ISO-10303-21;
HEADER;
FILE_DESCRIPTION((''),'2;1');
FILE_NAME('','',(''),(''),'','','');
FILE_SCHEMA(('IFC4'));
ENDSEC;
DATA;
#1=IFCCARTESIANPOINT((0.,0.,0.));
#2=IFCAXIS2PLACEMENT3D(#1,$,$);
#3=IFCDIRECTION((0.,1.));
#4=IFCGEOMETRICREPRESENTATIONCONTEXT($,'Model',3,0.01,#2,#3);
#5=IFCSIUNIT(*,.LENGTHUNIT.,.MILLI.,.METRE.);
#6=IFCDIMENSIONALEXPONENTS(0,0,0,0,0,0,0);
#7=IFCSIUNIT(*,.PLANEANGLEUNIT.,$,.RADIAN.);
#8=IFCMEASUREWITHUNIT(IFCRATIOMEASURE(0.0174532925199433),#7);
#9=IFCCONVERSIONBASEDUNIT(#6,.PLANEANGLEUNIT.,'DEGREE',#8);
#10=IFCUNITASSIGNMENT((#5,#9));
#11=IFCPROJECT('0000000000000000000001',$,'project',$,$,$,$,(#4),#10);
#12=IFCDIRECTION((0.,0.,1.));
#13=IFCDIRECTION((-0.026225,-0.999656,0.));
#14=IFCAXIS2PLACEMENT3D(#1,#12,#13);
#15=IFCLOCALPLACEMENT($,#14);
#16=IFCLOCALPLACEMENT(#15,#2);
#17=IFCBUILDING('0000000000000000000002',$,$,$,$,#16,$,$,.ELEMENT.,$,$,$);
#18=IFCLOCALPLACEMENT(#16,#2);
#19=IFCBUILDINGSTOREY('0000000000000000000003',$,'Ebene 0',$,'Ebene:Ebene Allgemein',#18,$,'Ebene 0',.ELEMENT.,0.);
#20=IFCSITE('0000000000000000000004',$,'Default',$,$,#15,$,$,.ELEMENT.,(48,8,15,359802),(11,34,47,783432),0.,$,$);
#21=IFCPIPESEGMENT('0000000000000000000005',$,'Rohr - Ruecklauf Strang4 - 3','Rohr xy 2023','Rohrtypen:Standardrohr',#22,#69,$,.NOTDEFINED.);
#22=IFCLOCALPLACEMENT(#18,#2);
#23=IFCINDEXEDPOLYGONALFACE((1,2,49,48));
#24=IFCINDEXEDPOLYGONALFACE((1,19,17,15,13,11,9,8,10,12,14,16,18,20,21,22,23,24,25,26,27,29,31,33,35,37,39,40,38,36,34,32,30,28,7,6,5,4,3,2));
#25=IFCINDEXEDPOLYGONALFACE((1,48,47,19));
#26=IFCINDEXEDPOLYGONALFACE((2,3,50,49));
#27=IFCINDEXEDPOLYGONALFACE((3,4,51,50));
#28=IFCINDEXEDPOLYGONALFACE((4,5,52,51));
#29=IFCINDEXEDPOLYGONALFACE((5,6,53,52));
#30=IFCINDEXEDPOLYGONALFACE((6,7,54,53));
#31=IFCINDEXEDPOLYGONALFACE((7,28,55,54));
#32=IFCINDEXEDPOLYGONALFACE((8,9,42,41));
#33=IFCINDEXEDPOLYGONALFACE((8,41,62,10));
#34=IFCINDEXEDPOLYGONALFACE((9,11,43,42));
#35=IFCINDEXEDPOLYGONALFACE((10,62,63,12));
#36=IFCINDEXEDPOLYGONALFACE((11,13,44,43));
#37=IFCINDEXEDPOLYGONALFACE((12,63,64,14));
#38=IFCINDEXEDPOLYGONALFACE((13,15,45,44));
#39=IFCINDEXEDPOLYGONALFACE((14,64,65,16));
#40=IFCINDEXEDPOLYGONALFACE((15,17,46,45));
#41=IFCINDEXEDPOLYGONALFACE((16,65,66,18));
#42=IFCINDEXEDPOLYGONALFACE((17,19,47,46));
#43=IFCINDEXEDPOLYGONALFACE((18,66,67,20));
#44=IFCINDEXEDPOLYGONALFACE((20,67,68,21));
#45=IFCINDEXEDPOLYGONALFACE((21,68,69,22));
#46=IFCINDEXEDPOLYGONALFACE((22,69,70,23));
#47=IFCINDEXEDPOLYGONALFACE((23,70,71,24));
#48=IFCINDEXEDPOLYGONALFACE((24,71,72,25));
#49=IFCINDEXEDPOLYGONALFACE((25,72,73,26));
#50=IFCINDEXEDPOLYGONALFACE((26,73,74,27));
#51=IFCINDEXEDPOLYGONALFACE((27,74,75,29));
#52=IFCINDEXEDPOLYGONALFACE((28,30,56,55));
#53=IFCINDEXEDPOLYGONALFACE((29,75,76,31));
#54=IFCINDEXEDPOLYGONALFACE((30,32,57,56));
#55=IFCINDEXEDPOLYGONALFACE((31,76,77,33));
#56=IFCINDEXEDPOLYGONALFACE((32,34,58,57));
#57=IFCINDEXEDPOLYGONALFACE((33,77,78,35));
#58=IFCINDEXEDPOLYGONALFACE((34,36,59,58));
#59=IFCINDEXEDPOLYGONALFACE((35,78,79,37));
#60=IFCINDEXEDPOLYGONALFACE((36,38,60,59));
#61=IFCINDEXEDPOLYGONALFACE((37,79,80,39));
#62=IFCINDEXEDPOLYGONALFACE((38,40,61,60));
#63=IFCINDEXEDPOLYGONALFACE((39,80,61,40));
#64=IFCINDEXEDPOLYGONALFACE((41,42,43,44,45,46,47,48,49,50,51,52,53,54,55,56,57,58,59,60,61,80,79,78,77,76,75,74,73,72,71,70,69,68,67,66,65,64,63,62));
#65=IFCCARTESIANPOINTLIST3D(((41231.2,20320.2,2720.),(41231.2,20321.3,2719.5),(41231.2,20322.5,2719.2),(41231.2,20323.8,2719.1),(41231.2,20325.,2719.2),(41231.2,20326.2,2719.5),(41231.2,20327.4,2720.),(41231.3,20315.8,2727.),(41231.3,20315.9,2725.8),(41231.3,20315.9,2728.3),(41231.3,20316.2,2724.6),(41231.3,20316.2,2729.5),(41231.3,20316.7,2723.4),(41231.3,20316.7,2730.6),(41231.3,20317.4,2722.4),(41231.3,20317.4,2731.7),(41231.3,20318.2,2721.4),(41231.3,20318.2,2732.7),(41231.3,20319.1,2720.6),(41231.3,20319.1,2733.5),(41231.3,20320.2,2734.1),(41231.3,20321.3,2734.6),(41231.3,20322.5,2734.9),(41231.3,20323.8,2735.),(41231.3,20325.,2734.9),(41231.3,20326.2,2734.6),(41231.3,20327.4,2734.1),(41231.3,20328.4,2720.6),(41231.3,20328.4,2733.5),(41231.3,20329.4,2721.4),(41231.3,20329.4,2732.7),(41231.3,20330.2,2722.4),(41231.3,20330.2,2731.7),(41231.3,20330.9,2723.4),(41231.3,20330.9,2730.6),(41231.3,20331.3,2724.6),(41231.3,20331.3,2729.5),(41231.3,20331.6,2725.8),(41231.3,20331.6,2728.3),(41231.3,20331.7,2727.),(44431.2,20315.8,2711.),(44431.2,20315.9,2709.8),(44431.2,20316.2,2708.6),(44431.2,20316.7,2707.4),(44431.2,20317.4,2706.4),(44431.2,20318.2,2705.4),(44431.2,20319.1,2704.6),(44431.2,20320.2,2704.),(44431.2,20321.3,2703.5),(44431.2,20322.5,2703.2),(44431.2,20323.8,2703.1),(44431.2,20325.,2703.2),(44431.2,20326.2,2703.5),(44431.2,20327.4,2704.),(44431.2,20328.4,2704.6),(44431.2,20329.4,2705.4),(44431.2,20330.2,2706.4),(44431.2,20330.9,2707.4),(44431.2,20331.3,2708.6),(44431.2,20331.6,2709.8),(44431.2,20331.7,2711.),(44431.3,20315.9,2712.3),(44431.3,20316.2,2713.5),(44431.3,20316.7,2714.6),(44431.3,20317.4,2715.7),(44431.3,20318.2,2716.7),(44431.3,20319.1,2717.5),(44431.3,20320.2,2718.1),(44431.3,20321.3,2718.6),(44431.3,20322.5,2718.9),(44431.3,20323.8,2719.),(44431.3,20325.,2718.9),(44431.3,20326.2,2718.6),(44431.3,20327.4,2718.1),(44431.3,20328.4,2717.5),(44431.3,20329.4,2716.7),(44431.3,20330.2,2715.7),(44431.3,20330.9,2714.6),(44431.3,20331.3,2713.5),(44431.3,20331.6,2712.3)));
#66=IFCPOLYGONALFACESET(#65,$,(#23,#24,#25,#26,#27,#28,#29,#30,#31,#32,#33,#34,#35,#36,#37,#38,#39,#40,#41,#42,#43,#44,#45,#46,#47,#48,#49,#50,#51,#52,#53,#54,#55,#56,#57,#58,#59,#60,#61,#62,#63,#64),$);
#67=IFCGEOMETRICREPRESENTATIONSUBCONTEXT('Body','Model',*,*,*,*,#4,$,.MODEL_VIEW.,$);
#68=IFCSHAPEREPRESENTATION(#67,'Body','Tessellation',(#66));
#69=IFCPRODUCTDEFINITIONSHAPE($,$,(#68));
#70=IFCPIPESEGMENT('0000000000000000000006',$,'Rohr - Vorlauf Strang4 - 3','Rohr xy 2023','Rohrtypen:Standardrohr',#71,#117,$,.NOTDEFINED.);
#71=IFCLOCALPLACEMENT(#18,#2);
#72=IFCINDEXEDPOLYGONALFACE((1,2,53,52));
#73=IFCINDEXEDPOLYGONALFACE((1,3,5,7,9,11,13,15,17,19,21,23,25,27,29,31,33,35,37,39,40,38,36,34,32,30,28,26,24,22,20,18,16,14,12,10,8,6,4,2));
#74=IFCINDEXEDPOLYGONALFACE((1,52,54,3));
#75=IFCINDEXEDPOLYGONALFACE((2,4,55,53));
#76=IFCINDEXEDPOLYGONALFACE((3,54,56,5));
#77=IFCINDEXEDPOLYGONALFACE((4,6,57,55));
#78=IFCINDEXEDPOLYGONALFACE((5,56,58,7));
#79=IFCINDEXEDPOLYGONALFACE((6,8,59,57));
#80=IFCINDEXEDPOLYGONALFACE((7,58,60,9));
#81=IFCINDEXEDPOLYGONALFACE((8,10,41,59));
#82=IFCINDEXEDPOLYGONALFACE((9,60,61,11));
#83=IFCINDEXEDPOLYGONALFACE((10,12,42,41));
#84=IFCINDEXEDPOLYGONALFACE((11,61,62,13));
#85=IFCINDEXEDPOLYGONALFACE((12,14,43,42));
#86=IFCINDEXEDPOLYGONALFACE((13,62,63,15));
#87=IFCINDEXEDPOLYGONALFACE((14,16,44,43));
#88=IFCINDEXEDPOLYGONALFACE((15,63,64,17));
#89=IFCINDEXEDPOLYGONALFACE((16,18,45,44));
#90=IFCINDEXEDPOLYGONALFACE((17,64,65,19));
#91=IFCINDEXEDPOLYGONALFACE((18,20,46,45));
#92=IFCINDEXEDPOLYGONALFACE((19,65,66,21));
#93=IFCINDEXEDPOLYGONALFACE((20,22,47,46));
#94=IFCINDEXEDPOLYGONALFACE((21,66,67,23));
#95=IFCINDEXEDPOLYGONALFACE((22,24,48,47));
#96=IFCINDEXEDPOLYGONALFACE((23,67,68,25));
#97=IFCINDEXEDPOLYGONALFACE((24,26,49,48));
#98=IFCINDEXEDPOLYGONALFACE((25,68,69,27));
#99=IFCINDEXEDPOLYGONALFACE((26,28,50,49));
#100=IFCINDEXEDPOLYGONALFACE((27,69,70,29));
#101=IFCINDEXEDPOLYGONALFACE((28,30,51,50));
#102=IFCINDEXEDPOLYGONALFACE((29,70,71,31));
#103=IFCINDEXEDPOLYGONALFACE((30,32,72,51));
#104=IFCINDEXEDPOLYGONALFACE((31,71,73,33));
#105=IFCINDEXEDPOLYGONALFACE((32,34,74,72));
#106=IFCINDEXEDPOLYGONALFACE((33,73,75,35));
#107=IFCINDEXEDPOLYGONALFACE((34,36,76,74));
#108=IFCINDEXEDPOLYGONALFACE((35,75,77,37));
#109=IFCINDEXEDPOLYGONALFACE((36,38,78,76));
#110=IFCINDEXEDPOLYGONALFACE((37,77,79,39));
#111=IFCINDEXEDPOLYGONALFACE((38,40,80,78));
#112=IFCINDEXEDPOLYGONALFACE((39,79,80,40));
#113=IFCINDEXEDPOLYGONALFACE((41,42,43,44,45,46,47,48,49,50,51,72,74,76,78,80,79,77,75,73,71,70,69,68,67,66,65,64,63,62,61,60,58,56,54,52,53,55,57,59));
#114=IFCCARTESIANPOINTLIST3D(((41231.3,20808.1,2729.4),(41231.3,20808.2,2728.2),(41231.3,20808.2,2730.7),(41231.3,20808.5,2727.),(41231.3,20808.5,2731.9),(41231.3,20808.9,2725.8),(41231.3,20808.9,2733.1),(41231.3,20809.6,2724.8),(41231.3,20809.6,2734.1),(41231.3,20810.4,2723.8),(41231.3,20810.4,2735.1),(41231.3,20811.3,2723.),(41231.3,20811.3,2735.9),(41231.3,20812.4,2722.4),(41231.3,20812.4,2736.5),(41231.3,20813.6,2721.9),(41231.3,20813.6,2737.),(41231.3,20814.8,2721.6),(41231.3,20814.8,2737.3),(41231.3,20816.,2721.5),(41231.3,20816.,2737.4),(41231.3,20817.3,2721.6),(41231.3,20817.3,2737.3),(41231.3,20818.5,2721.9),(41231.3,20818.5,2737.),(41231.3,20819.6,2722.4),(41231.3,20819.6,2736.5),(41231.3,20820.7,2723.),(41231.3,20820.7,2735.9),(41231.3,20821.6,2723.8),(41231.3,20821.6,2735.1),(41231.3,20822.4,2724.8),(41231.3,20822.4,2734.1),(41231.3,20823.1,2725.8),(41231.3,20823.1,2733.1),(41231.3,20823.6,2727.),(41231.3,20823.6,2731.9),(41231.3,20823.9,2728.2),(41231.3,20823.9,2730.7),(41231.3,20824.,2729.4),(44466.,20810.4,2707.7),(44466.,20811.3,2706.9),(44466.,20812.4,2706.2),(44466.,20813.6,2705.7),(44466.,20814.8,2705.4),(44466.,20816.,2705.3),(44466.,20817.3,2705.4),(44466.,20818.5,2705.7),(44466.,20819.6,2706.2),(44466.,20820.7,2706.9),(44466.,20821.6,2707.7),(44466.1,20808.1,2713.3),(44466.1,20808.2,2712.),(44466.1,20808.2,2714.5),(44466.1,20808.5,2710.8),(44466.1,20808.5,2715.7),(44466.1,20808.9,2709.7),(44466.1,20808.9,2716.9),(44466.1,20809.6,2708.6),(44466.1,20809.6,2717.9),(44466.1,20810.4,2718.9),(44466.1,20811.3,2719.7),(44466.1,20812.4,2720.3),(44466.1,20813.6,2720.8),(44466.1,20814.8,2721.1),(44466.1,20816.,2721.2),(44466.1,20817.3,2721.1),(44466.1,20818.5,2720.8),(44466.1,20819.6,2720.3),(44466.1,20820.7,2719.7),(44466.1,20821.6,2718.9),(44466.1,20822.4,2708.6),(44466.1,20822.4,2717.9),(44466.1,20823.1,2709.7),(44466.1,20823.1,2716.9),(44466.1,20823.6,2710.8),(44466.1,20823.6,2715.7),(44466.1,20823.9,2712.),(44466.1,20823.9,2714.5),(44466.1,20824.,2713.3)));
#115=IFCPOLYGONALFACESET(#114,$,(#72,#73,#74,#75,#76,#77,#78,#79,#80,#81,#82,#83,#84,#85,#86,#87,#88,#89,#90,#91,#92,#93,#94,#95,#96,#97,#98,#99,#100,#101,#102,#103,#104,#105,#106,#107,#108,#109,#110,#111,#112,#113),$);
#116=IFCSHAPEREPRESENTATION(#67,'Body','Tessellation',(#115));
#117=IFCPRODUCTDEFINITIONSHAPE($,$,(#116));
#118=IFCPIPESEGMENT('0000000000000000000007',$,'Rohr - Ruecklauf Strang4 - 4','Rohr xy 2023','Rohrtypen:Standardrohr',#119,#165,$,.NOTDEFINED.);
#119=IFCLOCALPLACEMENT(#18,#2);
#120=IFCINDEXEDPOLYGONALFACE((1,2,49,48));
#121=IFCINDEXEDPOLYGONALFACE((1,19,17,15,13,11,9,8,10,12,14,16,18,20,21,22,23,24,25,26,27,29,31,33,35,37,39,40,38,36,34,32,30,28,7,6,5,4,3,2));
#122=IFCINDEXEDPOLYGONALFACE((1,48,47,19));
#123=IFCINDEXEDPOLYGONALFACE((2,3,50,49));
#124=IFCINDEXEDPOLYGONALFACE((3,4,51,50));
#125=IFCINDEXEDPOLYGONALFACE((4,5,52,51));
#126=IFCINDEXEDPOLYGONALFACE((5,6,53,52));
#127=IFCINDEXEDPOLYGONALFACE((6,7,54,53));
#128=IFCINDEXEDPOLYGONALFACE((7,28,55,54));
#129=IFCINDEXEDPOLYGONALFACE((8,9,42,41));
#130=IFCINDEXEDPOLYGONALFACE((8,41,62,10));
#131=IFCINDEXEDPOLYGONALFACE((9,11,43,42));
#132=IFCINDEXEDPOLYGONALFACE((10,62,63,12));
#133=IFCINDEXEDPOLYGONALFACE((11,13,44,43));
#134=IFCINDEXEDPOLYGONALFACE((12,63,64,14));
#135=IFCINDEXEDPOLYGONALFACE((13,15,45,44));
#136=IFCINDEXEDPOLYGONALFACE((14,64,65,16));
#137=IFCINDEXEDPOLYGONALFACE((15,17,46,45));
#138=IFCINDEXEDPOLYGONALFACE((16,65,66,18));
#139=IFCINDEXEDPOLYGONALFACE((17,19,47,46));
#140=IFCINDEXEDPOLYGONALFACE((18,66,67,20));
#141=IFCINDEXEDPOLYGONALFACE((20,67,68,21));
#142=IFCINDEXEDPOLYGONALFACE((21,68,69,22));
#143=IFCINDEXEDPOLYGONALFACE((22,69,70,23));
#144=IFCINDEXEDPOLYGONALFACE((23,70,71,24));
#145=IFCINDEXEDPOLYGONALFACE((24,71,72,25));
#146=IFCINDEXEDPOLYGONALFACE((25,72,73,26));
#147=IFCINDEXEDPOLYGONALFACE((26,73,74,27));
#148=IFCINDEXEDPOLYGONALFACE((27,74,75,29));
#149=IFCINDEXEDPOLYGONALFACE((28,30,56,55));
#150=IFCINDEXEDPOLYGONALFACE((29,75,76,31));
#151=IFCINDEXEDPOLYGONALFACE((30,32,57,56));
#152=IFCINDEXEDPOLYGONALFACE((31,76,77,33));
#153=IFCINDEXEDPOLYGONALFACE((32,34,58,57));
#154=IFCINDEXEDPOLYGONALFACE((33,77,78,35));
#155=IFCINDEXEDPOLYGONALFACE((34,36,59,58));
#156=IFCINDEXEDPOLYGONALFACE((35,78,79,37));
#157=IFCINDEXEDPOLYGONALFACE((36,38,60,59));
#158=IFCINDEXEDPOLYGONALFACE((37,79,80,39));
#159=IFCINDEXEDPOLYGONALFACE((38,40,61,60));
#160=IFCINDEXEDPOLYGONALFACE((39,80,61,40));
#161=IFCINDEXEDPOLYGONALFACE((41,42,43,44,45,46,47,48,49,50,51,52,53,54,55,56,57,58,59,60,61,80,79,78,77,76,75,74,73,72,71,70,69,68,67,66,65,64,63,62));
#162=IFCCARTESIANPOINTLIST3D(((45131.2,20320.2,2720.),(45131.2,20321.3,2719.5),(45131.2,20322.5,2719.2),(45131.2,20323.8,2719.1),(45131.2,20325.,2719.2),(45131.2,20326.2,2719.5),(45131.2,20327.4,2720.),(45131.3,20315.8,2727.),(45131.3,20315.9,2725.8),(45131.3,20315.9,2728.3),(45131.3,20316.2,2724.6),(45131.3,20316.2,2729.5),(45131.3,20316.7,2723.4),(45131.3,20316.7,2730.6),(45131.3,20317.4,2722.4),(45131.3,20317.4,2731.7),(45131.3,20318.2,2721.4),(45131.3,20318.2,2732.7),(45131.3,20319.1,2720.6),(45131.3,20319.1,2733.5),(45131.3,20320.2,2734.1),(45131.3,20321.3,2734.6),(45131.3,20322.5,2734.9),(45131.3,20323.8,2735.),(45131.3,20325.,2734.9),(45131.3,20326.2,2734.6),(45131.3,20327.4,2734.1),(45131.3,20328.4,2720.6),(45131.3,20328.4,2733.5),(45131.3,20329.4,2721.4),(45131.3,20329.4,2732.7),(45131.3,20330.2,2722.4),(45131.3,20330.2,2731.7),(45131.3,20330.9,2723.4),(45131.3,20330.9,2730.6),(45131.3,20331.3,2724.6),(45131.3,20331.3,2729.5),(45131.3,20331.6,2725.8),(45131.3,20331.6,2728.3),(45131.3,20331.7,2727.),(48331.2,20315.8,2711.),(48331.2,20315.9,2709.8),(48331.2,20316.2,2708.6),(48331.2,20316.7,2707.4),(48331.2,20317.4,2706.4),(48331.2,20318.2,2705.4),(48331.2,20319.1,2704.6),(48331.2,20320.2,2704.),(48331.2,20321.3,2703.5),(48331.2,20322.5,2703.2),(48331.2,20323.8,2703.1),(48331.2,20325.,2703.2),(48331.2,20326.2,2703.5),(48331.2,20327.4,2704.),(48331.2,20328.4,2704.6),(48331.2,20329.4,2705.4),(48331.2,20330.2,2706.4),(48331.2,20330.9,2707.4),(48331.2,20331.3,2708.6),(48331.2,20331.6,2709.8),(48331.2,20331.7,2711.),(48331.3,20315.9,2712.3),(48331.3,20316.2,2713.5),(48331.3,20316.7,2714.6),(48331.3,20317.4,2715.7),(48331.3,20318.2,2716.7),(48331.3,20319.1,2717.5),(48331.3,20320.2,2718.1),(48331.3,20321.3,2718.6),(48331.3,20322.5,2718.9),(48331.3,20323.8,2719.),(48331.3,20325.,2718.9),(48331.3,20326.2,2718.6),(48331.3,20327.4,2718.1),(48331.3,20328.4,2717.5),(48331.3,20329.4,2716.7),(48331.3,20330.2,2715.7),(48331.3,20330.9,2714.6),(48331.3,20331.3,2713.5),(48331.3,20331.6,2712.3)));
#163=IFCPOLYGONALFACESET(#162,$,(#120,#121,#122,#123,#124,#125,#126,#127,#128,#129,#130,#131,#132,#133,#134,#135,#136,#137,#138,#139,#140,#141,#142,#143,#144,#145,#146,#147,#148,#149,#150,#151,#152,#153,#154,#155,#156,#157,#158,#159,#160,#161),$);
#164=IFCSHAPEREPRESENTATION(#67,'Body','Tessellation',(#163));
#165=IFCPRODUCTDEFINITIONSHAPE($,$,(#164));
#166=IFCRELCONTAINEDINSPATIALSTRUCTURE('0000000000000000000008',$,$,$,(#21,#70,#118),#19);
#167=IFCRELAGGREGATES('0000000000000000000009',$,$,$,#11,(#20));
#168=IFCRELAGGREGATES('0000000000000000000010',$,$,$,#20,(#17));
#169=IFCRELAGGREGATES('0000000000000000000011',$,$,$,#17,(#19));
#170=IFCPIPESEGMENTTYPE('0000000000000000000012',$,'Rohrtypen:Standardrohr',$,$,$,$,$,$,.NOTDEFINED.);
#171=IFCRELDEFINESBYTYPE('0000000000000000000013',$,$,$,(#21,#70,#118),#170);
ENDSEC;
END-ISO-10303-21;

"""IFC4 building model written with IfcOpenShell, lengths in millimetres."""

from ifc_helpers import new_model, entity, si_unit, converted_unit, direction, frame, origin, place, context, subcontext, project, spatial, indexed_curve, outline, extrude, type_object, element, save


model = new_model("IFC4")

# Units and contexts
model_context = context("Model", 3, precision=0.01, world=origin(), true_north=direction((0.0, 1.0)))
body_context = subcontext(model_context, "Body", "Model", "MODEL_VIEW")
ifc_project = project(units=[si_unit("LENGTHUNIT", "METRE", prefix="MILLI"), converted_unit("PLANEANGLEUNIT", "DEGREE", entity("IfcRatioMeasure", 0.0174532925199433), si_unit("PLANEANGLEUNIT", "RADIAN"), dimensions=[0, 0, 0, 0, 0, 0, 0])], contexts=[model_context])

# Site, building, storey
site_placement = place(None, frame((0.0, 0.0, 0.0), z_axis=(0.0, 0.0, 1.0), x_axis=(-0.026225, -0.999656, 0.0)))
site = spatial("IfcSite", under=ifc_project, at=site_placement, Name="Default", CompositionType="ELEMENT", RefLatitude=(48, 8, 15, 359802), RefLongitude=(11, 34, 47, 783432), RefElevation=0.0)
building_placement = place(site_placement, origin())
building = spatial("IfcBuilding", under=site, at=building_placement, CompositionType="ELEMENT")
storey_placement = place(building_placement, origin())
storey = spatial("IfcBuildingStorey", under=building, at=storey_placement, Name="Ebene 0", ObjectType="Ebene:Ebene Allgemein", LongName="Ebene 0", CompositionType="ELEMENT", Elevation=0.0)

# Pipe segments
pipe_segment_type = type_object("IfcPipeSegmentType", Name="Rohrtypen:Standardrohr", PredefinedType="NOTDEFINED")
pipe_segment_1_placement = place(storey_placement, origin())
element("IfcPipeSegment", 1, at=pipe_segment_1_placement, inside=storey, type_object=pipe_segment_type, Name="Rohr - Ruecklauf Strang4 - 3", Description="Rohr xy 2023", ObjectType="Rohrtypen:Standardrohr", PredefinedType="NOTDEFINED", context=body_context, shape_type="SweptSolid", body=[
    extrude(outline(indexed_curve([(7.9, 0.0), (7.8, 1.2), (7.6, 2.5), (7.1, 3.6), (6.4, 4.7), (5.6, 5.6), (4.7, 6.4), (3.6, 7.1), (2.5, 7.6), (1.2, 7.8), (0.0, 7.9), (-1.2, 7.8), (-2.5, 7.6), (-3.6, 7.1), (-4.7, 6.4), (-5.6, 5.6), (-6.4, 4.7), (-7.1, 3.6), (-7.6, 2.5), (-7.8, 1.2), (-7.9, 0.0), (-7.8, -1.2), (-7.6, -2.5), (-7.1, -3.6), (-6.4, -4.7), (-5.6, -5.6), (-4.7, -6.4), (-3.6, -7.1), (-2.5, -7.6), (-1.2, -7.8), (0.0, -7.9), (1.2, -7.8), (2.5, -7.6), (3.6, -7.1), (4.7, -6.4), (5.6, -5.6), (6.4, -4.7), (7.1, -3.6), (7.6, -2.5), (7.8, -1.2), (7.9, 0.0)], self_intersect=False)), frame((44431.2, 20323.8, 2711.0), z_axis=(-0.999988, 0.0, 0.005), x_axis=(0.0, 1.0, 0.0)), (0.0, 0.0, 1.0), 3200.0),
])
pipe_segment_2_placement = place(storey_placement, origin())
element("IfcPipeSegment", 2, at=pipe_segment_2_placement, inside=storey, type_object=pipe_segment_type, Name="Rohr - Vorlauf Strang4 - 3", Description="Rohr xy 2023", ObjectType="Rohrtypen:Standardrohr", PredefinedType="NOTDEFINED", context=body_context, shape_type="SweptSolid", body=[
    extrude(outline(indexed_curve([(7.9, 0.0), (7.8, 1.2), (7.6, 2.5), (7.1, 3.6), (6.4, 4.7), (5.6, 5.6), (4.7, 6.4), (3.6, 7.1), (2.5, 7.6), (1.2, 7.8), (0.0, 7.9), (-1.2, 7.8), (-2.5, 7.6), (-3.6, 7.1), (-4.7, 6.4), (-5.6, 5.6), (-6.4, 4.7), (-7.1, 3.6), (-7.6, 2.5), (-7.8, 1.2), (-7.9, 0.0), (-7.8, -1.2), (-7.6, -2.5), (-7.1, -3.6), (-6.4, -4.7), (-5.6, -5.6), (-4.7, -6.4), (-3.6, -7.1), (-2.5, -7.6), (-1.2, -7.8), (0.0, -7.9), (1.2, -7.8), (2.5, -7.6), (3.6, -7.1), (4.7, -6.4), (5.6, -5.6), (6.4, -4.7), (7.1, -3.6), (7.6, -2.5), (7.8, -1.2), (7.9, 0.0)], self_intersect=False)), frame((44466.1, 20816.0, 2713.3), z_axis=(-0.999988, 0.0, 0.005), x_axis=(0.0, 1.0, 0.0)), (0.0, 0.0, 1.0), 3234.8),
])
pipe_segment_3_placement = place(storey_placement, origin())
element("IfcPipeSegment", 3, at=pipe_segment_3_placement, inside=storey, type_object=pipe_segment_type, Name="Rohr - Ruecklauf Strang4 - 4", Description="Rohr xy 2023", ObjectType="Rohrtypen:Standardrohr", PredefinedType="NOTDEFINED", context=body_context, shape_type="SweptSolid", body=[
    extrude(outline(indexed_curve([(7.9, 0.0), (7.8, 1.2), (7.6, 2.5), (7.1, 3.6), (6.4, 4.7), (5.6, 5.6), (4.7, 6.4), (3.6, 7.1), (2.5, 7.6), (1.2, 7.8), (0.0, 7.9), (-1.2, 7.8), (-2.5, 7.6), (-3.6, 7.1), (-4.7, 6.4), (-5.6, 5.6), (-6.4, 4.7), (-7.1, 3.6), (-7.6, 2.5), (-7.8, 1.2), (-7.9, 0.0), (-7.8, -1.2), (-7.6, -2.5), (-7.1, -3.6), (-6.4, -4.7), (-5.6, -5.6), (-4.7, -6.4), (-3.6, -7.1), (-2.5, -7.6), (-1.2, -7.8), (0.0, -7.9), (1.2, -7.8), (2.5, -7.6), (3.6, -7.1), (4.7, -6.4), (5.6, -5.6), (6.4, -4.7), (7.1, -3.6), (7.6, -2.5), (7.8, -1.2), (7.9, 0.0)], self_intersect=False)), frame((48331.2, 20323.8, 2711.0), z_axis=(-0.999988, 0.0, 0.005), x_axis=(0.0, 1.0, 0.0)), (0.0, 0.0, 1.0), 3200.0),
])

save(model, "model.ifc")
